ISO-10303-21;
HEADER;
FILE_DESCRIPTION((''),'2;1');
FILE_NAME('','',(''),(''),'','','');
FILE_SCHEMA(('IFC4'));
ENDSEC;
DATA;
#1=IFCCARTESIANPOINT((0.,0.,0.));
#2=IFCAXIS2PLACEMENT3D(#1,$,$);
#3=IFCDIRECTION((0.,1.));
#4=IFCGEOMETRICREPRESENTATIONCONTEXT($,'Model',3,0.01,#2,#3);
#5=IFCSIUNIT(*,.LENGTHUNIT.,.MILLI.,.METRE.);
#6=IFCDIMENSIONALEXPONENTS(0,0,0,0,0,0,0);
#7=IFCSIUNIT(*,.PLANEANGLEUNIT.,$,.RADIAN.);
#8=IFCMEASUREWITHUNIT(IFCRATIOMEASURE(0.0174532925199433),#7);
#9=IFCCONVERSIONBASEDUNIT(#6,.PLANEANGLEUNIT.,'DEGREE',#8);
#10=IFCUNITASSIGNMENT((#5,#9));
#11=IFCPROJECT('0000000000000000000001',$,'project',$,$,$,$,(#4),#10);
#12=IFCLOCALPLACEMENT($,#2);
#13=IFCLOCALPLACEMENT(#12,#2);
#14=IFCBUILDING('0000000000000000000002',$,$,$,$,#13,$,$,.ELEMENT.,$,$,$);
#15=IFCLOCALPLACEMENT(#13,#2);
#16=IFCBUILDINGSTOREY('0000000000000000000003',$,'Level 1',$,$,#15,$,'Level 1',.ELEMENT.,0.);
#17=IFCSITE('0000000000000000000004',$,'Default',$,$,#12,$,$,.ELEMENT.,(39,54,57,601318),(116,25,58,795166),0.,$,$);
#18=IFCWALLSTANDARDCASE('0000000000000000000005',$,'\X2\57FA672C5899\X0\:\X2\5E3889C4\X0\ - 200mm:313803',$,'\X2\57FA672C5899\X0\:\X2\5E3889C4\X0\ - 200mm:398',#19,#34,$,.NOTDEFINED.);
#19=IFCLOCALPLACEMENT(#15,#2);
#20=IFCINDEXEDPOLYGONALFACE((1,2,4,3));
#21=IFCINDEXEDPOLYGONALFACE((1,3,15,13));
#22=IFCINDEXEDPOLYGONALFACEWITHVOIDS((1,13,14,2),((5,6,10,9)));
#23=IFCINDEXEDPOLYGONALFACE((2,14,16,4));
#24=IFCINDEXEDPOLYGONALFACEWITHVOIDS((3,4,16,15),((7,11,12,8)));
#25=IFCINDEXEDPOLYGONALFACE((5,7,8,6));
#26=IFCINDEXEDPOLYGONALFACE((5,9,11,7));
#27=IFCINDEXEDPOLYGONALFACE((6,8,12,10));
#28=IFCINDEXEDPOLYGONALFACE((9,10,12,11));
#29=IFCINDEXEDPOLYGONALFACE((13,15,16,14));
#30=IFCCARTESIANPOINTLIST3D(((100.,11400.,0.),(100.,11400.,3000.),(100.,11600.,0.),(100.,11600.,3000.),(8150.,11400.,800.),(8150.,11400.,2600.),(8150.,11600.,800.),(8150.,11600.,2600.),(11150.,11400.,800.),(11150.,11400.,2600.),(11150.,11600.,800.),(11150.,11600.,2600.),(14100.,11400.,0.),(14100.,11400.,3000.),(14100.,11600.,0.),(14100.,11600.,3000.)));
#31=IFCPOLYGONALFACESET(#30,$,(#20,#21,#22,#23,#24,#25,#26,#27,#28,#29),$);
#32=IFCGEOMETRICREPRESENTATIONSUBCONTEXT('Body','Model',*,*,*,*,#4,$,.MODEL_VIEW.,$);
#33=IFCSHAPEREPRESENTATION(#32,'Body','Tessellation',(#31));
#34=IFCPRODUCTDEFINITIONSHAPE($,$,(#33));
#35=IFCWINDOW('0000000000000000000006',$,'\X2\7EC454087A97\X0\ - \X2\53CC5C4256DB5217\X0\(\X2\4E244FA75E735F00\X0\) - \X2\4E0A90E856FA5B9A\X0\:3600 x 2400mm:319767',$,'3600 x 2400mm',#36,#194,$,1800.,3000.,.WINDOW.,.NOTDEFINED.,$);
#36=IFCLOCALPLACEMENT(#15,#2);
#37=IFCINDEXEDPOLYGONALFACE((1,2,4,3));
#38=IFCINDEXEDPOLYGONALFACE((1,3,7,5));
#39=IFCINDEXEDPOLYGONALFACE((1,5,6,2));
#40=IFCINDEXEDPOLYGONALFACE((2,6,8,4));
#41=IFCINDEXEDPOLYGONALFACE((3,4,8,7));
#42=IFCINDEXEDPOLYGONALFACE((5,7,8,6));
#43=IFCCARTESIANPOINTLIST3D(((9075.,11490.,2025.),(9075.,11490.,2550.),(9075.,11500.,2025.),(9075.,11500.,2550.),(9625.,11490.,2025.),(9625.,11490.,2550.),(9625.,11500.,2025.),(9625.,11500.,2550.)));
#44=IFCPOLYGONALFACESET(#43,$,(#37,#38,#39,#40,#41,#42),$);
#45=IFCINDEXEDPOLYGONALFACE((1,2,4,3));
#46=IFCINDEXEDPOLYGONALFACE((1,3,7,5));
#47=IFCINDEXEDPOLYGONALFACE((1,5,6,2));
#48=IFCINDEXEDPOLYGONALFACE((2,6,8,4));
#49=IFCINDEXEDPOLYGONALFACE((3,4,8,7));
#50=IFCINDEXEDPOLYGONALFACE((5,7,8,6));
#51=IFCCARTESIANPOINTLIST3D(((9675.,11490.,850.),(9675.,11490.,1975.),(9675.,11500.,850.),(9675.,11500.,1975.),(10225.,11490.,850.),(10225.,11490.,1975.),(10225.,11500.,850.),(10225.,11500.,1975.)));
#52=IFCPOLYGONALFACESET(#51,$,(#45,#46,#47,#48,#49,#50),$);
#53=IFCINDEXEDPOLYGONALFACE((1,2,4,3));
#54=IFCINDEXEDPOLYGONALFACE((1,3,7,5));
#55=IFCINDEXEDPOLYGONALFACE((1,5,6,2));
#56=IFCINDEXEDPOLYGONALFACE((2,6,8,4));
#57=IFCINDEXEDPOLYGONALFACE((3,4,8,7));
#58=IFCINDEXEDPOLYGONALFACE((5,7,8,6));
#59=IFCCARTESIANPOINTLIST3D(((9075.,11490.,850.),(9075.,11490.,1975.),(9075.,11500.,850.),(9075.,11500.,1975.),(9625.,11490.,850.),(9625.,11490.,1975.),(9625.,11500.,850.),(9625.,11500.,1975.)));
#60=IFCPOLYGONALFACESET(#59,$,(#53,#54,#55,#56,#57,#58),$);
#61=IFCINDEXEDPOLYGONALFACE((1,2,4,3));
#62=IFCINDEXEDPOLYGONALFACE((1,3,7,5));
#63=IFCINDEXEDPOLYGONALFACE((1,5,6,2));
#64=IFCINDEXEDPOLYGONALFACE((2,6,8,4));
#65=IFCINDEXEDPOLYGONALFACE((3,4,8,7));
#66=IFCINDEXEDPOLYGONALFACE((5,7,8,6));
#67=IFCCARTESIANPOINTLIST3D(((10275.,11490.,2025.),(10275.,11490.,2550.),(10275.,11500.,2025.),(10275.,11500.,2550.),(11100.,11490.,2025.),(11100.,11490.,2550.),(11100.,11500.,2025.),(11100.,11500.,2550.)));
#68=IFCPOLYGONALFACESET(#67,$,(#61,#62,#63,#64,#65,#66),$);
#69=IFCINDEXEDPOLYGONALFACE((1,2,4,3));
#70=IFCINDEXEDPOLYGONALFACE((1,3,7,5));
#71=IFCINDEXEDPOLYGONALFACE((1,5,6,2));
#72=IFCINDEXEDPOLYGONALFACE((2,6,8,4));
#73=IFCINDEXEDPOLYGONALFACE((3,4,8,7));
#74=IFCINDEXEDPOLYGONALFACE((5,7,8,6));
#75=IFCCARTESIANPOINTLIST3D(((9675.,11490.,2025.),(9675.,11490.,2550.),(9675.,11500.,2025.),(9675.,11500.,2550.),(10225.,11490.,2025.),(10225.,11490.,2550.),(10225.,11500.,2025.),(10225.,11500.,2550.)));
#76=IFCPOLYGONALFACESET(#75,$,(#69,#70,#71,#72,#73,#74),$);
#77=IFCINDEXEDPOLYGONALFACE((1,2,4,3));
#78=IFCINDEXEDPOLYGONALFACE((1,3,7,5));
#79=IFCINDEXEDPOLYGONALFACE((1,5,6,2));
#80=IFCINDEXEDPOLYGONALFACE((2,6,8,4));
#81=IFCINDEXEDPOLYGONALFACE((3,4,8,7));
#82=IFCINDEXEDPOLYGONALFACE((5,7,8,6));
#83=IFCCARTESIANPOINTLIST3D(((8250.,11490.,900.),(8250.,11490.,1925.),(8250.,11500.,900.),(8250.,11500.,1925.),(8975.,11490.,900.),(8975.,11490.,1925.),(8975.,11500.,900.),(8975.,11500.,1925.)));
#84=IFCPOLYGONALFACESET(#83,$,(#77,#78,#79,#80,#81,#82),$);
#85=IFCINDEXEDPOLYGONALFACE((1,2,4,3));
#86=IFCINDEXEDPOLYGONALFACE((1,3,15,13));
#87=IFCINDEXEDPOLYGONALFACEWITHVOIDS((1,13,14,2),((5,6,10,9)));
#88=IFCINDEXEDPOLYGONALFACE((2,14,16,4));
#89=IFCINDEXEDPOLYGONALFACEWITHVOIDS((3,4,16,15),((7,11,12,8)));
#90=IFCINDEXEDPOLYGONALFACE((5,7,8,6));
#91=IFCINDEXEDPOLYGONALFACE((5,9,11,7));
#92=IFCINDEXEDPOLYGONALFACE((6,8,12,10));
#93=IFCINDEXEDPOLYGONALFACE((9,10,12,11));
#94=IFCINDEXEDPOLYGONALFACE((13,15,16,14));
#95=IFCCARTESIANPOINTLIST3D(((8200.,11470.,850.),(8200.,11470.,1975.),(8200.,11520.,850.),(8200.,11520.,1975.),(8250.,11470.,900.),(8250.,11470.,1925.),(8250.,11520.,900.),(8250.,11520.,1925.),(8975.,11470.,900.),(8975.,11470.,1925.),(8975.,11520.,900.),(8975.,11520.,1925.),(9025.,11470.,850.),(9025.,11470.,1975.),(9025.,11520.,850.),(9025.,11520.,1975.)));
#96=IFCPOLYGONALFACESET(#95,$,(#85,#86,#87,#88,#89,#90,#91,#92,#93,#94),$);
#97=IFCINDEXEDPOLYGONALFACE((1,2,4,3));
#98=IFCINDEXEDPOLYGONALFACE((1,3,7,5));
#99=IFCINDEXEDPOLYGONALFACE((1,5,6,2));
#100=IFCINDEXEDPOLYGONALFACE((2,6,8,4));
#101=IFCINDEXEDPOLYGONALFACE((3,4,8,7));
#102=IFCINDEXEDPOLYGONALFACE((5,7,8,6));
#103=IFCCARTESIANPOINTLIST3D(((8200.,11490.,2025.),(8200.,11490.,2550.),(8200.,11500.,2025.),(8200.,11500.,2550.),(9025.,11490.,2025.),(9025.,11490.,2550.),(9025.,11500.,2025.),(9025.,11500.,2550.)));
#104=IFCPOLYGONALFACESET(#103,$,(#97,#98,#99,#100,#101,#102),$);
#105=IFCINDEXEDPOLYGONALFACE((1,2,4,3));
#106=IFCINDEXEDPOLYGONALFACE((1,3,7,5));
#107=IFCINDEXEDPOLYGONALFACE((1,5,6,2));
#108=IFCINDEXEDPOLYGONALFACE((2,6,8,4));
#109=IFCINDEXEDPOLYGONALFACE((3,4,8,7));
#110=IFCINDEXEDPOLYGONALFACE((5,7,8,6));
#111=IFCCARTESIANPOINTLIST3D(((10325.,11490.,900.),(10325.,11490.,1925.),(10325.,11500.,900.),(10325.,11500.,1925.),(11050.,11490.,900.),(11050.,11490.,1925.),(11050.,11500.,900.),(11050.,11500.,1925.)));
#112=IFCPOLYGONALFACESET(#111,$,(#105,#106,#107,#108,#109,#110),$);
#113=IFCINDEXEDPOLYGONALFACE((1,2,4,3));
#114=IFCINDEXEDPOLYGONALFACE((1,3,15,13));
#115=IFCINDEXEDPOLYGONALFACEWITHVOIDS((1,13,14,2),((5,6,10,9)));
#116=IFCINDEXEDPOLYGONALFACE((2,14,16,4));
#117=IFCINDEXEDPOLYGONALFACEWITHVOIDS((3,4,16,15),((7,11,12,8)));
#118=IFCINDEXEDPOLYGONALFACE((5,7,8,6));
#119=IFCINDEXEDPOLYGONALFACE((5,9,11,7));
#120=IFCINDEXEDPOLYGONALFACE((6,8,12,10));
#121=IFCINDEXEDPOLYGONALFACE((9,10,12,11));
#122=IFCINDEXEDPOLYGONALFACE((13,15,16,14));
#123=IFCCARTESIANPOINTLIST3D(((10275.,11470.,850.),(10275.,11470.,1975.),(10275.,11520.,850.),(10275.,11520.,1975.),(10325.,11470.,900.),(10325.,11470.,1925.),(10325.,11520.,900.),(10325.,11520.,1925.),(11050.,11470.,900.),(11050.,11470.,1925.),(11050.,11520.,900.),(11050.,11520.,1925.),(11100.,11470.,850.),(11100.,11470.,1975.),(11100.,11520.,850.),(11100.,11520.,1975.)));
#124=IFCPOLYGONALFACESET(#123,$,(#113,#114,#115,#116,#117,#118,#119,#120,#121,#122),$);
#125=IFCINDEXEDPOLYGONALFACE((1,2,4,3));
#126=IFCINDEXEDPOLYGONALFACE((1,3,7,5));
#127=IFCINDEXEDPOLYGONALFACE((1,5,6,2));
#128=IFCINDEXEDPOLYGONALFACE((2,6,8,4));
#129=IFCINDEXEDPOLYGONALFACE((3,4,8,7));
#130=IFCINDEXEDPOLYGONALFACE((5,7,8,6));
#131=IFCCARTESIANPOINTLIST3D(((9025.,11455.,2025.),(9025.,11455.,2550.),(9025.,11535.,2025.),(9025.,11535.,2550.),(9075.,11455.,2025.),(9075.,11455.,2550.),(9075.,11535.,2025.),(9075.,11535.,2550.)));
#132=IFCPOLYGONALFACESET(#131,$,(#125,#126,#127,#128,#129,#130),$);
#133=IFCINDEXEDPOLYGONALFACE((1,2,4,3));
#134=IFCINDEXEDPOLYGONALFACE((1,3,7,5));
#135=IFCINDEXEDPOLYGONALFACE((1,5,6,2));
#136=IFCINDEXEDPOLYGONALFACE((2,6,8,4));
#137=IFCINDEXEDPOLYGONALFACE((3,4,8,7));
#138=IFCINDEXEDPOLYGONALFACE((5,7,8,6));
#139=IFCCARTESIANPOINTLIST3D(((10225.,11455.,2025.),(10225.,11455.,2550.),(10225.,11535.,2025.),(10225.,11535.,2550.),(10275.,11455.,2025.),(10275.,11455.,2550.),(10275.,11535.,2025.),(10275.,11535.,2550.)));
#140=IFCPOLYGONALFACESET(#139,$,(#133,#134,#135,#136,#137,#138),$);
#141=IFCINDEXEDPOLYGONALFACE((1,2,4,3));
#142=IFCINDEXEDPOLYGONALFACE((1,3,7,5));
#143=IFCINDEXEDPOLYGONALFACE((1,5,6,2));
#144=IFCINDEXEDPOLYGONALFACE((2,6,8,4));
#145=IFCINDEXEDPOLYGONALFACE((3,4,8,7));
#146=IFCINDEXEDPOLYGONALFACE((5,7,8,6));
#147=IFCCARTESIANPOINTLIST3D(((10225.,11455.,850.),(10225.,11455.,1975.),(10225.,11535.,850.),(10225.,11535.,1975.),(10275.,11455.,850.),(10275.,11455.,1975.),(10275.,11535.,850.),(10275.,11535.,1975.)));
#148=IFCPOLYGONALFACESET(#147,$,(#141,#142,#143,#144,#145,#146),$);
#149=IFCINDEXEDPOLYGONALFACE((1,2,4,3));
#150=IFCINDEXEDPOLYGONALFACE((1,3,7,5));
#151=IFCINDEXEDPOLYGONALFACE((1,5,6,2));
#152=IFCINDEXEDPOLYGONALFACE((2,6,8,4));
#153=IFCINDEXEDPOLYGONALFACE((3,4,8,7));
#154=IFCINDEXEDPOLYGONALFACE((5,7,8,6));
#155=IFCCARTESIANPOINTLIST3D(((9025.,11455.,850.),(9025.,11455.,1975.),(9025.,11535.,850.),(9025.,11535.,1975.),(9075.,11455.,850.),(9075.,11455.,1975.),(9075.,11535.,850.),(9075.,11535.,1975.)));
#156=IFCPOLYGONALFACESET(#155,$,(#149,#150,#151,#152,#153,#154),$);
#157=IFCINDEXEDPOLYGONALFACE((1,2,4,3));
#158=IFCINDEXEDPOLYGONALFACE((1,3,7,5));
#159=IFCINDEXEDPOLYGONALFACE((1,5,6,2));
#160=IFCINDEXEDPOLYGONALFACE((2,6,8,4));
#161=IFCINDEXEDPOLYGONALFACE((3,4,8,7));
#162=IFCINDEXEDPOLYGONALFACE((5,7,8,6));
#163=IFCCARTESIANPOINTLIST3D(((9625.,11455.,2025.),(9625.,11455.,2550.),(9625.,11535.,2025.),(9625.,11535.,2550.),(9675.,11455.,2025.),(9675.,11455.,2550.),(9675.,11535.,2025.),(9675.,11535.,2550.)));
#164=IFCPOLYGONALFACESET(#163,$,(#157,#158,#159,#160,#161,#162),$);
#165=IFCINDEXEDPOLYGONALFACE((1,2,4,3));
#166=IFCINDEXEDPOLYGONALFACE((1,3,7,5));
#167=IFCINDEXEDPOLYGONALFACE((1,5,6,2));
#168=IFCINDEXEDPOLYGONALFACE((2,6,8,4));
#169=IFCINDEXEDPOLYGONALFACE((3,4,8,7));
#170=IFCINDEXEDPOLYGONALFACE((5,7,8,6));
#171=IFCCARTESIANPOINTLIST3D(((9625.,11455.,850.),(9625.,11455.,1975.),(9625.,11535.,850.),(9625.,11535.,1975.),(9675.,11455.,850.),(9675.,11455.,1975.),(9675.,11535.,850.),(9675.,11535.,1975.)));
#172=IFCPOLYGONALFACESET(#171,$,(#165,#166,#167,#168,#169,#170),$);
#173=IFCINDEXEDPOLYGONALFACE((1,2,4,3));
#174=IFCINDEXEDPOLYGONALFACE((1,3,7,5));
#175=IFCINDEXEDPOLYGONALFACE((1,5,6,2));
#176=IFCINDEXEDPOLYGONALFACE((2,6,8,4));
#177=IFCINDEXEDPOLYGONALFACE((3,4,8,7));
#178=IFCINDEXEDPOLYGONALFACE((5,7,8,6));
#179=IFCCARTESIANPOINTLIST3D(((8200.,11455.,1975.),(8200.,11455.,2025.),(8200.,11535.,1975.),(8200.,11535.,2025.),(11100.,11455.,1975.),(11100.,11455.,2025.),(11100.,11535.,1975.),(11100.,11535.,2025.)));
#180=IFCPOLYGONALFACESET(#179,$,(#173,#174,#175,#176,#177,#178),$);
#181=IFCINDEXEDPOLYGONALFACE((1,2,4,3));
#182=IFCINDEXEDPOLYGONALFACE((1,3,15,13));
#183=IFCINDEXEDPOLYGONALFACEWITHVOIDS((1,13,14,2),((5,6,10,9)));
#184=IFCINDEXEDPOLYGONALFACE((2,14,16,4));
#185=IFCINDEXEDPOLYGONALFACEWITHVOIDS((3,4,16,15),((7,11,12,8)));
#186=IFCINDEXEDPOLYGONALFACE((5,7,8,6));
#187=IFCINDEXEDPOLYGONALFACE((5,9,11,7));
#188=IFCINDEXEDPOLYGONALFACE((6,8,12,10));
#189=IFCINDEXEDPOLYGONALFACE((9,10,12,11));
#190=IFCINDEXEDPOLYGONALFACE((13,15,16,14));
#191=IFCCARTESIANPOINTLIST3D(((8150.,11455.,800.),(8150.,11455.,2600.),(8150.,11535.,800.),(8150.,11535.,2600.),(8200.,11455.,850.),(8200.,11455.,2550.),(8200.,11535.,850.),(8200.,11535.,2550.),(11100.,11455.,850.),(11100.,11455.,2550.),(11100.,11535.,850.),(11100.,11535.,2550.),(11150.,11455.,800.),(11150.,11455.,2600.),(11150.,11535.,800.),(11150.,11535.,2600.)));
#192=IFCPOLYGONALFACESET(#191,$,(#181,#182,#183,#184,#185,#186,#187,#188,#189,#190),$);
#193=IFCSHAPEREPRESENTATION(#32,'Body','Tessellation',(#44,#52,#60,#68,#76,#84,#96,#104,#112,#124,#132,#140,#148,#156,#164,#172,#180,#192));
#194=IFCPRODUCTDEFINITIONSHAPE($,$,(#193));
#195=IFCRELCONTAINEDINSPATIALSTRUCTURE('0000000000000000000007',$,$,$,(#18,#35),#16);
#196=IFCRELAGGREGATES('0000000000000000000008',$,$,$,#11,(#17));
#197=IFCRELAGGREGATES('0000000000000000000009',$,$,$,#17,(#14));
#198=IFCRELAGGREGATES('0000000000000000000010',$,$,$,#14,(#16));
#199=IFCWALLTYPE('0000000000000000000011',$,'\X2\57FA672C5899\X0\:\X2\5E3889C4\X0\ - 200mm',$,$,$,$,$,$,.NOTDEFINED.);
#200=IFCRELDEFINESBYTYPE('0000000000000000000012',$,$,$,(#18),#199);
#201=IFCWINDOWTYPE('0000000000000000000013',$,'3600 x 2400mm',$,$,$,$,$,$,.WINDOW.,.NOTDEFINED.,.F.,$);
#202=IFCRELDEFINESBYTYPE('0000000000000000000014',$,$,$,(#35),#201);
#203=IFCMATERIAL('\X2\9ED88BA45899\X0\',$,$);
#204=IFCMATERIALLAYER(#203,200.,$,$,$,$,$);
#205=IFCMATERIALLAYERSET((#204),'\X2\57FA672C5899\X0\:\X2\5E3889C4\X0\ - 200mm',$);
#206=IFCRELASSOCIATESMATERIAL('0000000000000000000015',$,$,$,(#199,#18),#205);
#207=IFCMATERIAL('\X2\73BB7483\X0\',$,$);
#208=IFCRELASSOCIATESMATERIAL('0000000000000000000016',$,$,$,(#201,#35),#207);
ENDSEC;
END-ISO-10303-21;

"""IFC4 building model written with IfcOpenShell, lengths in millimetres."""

from ifc_helpers import new_model, entity, si_unit, converted_unit, direction, frame, frame_2d, origin, origin_2d_with_axis, place, context, subcontext, project, spatial, polyline, rectangle, outline, extrude, source, transform, mapped, material, layer, layer_set, layer_usage, type_object, type_shapes, element, fill, save


model = new_model("IFC4")

# Units and contexts
model_context = context("Model", 3, precision=0.01, world=origin(), true_north=direction((0.0, 1.0)))
body_context = subcontext(model_context, "Body", "Model", "MODEL_VIEW")
ifc_project = project(units=[si_unit("LENGTHUNIT", "METRE", prefix="MILLI"), converted_unit("PLANEANGLEUNIT", "DEGREE", entity("IfcRatioMeasure", 0.0174532925199433), si_unit("PLANEANGLEUNIT", "RADIAN"), dimensions=[0, 0, 0, 0, 0, 0, 0])], contexts=[model_context])

# Site, building, storey
site_placement = place(None, origin())
site = spatial("IfcSite", under=ifc_project, at=site_placement, Name="Default", CompositionType="ELEMENT", RefLatitude=(39, 54, 57, 601318), RefLongitude=(116, 25, 58, 795166), RefElevation=0.0)
building_placement = place(site_placement, origin())
building = spatial("IfcBuilding", under=site, at=building_placement, CompositionType="ELEMENT")
storey_placement = place(building_placement, origin())
storey = spatial("IfcBuildingStorey", under=building, at=storey_placement, Name="Level 1", LongName="Level 1", CompositionType="ELEMENT", Elevation=0.0)

# Shared definitions
ifc_material_1 = material(Name="默认墙")
ifc_layer = layer(ifc_material_1, 200.0)
ifc_layer_set = layer_set([ifc_layer], Name="基本墙:常规 - 200mm")
wall_type = type_object("IfcWallType", Name="基本墙:常规 - 200mm", PredefinedType="NOTDEFINED", material=ifc_layer_set)
ifc_material_2 = material(Name="玻璃")
window_type_1 = type_object("IfcWindowType", Name="3600 x 2400mm", ParameterTakesPrecedence=False, PartitioningType="NOTDEFINED", PredefinedType="WINDOW", material=ifc_material_2)
shared_shape_1 = source(origin(), body_context, "Body", "SweptSolid", [
    extrude(rectangle(XDim=10.0, YDim=550.0, at=origin_2d_with_axis()), frame((1200.0, 95.0, 1225.0), z_axis=(0.0, 0.0, 1.0), x_axis=(0.0, 1.0, 0.0)), (0.0, 0.0, 1.0), 525.0),
    extrude(rectangle(XDim=10.0, YDim=550.0, at=origin_2d_with_axis()), frame((1800.0, 95.0, 50.0), z_axis=(0.0, 0.0, 1.0), x_axis=(0.0, 1.0, 0.0)), (0.0, 0.0, 1.0), 1125.0),
    extrude(rectangle(XDim=10.0, YDim=550.0, at=origin_2d_with_axis()), frame((1200.0, 95.0, 50.0), z_axis=(0.0, 0.0, 1.0), x_axis=(0.0, 1.0, 0.0)), (0.0, 0.0, 1.0), 1125.0),
    extrude(rectangle(XDim=10.0, YDim=825.0, at=frame_2d((0.0, 0.0), x_axis=(1.0, 0.0))), frame((2537.5, 95.0, 1225.0), z_axis=(0.0, 0.0, 1.0), x_axis=(0.0, 1.0, 0.0)), (0.0, 0.0, 1.0), 525.0),
    extrude(rectangle(XDim=10.0, YDim=550.0, at=frame_2d((0.0, 0.0), x_axis=(1.0, 0.0))), frame((1800.0, 95.0, 1225.0), z_axis=(0.0, 0.0, 1.0), x_axis=(0.0, 1.0, 0.0)), (0.0, 0.0, 1.0), 525.0),
    extrude(rectangle(XDim=10.0, YDim=725.0, at=frame_2d((0.0, 0.0), x_axis=(1.0, 0.0))), frame((462.5, 95.0, 100.0), z_axis=(0.0, 0.0, 1.0), x_axis=(0.0, 1.0, 0.0)), (0.0, 0.0, 1.0), 1025.0),
    extrude(outline(polyline([(-562.5, -412.5), (562.5, -412.5), (562.5, 412.5), (-562.5, 412.5), (-562.5, -412.5)]), holes=[polyline([(512.5, -362.5), (-512.5, -362.5), (-512.5, 362.5), (512.5, 362.5), (512.5, -362.5)])]), frame((462.5, 70.0, 612.5), z_axis=(0.0, 1.0, 0.0), x_axis=(0.0, 0.0, -1.0)), (0.0, 0.0, 1.0), 50.0),
    extrude(rectangle(XDim=10.0, YDim=825.0, at=origin_2d_with_axis()), frame((462.5, 95.0, 1225.0), z_axis=(0.0, 0.0, 1.0), x_axis=(0.0, 1.0, 0.0)), (0.0, 0.0, 1.0), 525.0),
    extrude(rectangle(XDim=10.0, YDim=725.0, at=frame_2d((0.0, 0.0), x_axis=(1.0, 0.0))), frame((2537.5, 95.0, 100.0), z_axis=(0.0, 0.0, 1.0), x_axis=(0.0, 1.0, 0.0)), (0.0, 0.0, 1.0), 1025.0),
    extrude(outline(polyline([(-562.5, -412.5), (562.5, -412.5), (562.5, 412.5), (-562.5, 412.5), (-562.5, -412.5)]), holes=[polyline([(512.5, -362.5), (-512.5, -362.5), (-512.5, 362.5), (512.5, 362.5), (512.5, -362.5)])]), frame((2537.5, 70.0, 612.5), z_axis=(0.0, 1.0, 0.0), x_axis=(0.0, 0.0, -1.0)), (0.0, 0.0, 1.0), 50.0),
    extrude(rectangle(XDim=80.0, YDim=50.0, at=origin_2d_with_axis()), frame((900.0, 95.0, 1225.0), z_axis=(0.0, 0.0, 1.0), x_axis=(0.0, -1.0, 0.0)), (0.0, 0.0, 1.0), 525.0),
    extrude(rectangle(XDim=80.0, YDim=50.0, at=frame_2d((0.0, 0.0), x_axis=(1.0, 0.0))), frame((2100.0, 95.0, 1225.0), z_axis=(0.0, 0.0, 1.0), x_axis=(0.0, -1.0, 0.0)), (0.0, 0.0, 1.0), 525.0),
    extrude(rectangle(XDim=80.0, YDim=50.0, at=origin_2d_with_axis()), frame((2100.0, 95.0, 50.0), z_axis=(0.0, 0.0, 1.0), x_axis=(0.0, -1.0, 0.0)), (0.0, 0.0, 1.0), 1125.0),
    extrude(rectangle(XDim=80.0, YDim=50.0, at=origin_2d_with_axis()), frame((900.0, 95.0, 50.0), z_axis=(0.0, 0.0, 1.0), x_axis=(0.0, -1.0, 0.0)), (0.0, 0.0, 1.0), 1125.0),
    extrude(rectangle(XDim=80.0, YDim=50.0, at=frame_2d((0.0, 0.0), x_axis=(1.0, 0.0))), frame((1500.0, 95.0, 1225.0), z_axis=(0.0, 0.0, 1.0), x_axis=(0.0, -1.0, 0.0)), (0.0, 0.0, 1.0), 525.0),
    extrude(rectangle(XDim=80.0, YDim=50.0, at=origin_2d_with_axis()), frame((1500.0, 95.0, 50.0), z_axis=(0.0, 0.0, 1.0), x_axis=(0.0, -1.0, 0.0)), (0.0, 0.0, 1.0), 1125.0),
    extrude(rectangle(XDim=80.0, YDim=2900.0, at=frame_2d((0.0, 0.0), x_axis=(1.0, 0.0))), frame((1500.0, 95.0, 1175.0), z_axis=(0.0, 0.0, 1.0), x_axis=(0.0, -1.0, 0.0)), (0.0, 0.0, 1.0), 50.0),
    extrude(outline(polyline([(-1500.0, -900.0), (1500.0, -900.0), (1500.0, 900.0), (-1500.0, 900.0), (-1500.0, -900.0)]), holes=[polyline([(1450.0, -850.0), (-1450.0, -850.0), (-1450.0, 850.0), (1450.0, 850.0), (1450.0, -850.0)])]), frame((1500.0, 55.0, 900.0), z_axis=(0.0, 1.0, 0.0), x_axis=(1.0, 0.0, 0.0)), (0.0, 0.0, 1.0), 80.0),
])
type_shapes(window_type_1, [shared_shape_1])

# Wall, opening, window
ifc_layer_usage_1 = layer_usage(ifc_layer_set, "AXIS2", "NEGATIVE", 100.0)
wall_1_placement = place(storey_placement, frame((100.0, 11500.0, 0.0)))
wall_1 = element("IfcWallStandardCase", 1, at=wall_1_placement, inside=storey, type_object=wall_type, material=ifc_layer_usage_1, Name="基本墙:常规 - 200mm:313803", ObjectType="基本墙:常规 - 200mm:398", PredefinedType="NOTDEFINED", context=body_context, shape_type="SweptSolid", body=[
    extrude(rectangle(XDim=14000.0, YDim=200.0, at=frame_2d((7000.0, 0.0), x_axis=(-1.0, 0.0))), origin(), (0.0, 0.0, 1.0), 3000.0),
])
opening_1_placement = place(wall_1_placement, frame((8050.0, -100.0, 800.0)))
opening_1 = element("IfcOpeningElement", 2, at=opening_1_placement, cuts=wall_1, ObjectType="Opening", PredefinedType="OPENING", context=body_context, shape_type="SweptSolid", body=[
    extrude(rectangle(XDim=1800.0, YDim=3000.0, at=frame_2d((900.0, 1500.0), x_axis=(1.0, 0.0))), frame((0.0, 0.0, 0.0), z_axis=(0.0, 1.0, 0.0), x_axis=(0.0, 0.0, 1.0)), (0.0, 0.0, 1.0), 200.0),
])
window_1_placement = place(opening_1_placement, origin())
window_1 = element("IfcWindow", 3, at=window_1_placement, inside=storey, type_object=window_type_1, material=ifc_material_2, Name="组合窗 - 双层四列(两侧平开) - 上部固定:3600 x 2400mm:319767", ObjectType="3600 x 2400mm", OverallHeight=1800.0, OverallWidth=3000.0, PartitioningType="NOTDEFINED", PredefinedType="WINDOW", context=body_context, shape_type="MappedRepresentation", body=[
    mapped(shared_shape_1, transform((0.0, 0.0, 0.0), scale=1.0)),
])
fill(opening_1, window_1)

save(model, "model.ifc")
